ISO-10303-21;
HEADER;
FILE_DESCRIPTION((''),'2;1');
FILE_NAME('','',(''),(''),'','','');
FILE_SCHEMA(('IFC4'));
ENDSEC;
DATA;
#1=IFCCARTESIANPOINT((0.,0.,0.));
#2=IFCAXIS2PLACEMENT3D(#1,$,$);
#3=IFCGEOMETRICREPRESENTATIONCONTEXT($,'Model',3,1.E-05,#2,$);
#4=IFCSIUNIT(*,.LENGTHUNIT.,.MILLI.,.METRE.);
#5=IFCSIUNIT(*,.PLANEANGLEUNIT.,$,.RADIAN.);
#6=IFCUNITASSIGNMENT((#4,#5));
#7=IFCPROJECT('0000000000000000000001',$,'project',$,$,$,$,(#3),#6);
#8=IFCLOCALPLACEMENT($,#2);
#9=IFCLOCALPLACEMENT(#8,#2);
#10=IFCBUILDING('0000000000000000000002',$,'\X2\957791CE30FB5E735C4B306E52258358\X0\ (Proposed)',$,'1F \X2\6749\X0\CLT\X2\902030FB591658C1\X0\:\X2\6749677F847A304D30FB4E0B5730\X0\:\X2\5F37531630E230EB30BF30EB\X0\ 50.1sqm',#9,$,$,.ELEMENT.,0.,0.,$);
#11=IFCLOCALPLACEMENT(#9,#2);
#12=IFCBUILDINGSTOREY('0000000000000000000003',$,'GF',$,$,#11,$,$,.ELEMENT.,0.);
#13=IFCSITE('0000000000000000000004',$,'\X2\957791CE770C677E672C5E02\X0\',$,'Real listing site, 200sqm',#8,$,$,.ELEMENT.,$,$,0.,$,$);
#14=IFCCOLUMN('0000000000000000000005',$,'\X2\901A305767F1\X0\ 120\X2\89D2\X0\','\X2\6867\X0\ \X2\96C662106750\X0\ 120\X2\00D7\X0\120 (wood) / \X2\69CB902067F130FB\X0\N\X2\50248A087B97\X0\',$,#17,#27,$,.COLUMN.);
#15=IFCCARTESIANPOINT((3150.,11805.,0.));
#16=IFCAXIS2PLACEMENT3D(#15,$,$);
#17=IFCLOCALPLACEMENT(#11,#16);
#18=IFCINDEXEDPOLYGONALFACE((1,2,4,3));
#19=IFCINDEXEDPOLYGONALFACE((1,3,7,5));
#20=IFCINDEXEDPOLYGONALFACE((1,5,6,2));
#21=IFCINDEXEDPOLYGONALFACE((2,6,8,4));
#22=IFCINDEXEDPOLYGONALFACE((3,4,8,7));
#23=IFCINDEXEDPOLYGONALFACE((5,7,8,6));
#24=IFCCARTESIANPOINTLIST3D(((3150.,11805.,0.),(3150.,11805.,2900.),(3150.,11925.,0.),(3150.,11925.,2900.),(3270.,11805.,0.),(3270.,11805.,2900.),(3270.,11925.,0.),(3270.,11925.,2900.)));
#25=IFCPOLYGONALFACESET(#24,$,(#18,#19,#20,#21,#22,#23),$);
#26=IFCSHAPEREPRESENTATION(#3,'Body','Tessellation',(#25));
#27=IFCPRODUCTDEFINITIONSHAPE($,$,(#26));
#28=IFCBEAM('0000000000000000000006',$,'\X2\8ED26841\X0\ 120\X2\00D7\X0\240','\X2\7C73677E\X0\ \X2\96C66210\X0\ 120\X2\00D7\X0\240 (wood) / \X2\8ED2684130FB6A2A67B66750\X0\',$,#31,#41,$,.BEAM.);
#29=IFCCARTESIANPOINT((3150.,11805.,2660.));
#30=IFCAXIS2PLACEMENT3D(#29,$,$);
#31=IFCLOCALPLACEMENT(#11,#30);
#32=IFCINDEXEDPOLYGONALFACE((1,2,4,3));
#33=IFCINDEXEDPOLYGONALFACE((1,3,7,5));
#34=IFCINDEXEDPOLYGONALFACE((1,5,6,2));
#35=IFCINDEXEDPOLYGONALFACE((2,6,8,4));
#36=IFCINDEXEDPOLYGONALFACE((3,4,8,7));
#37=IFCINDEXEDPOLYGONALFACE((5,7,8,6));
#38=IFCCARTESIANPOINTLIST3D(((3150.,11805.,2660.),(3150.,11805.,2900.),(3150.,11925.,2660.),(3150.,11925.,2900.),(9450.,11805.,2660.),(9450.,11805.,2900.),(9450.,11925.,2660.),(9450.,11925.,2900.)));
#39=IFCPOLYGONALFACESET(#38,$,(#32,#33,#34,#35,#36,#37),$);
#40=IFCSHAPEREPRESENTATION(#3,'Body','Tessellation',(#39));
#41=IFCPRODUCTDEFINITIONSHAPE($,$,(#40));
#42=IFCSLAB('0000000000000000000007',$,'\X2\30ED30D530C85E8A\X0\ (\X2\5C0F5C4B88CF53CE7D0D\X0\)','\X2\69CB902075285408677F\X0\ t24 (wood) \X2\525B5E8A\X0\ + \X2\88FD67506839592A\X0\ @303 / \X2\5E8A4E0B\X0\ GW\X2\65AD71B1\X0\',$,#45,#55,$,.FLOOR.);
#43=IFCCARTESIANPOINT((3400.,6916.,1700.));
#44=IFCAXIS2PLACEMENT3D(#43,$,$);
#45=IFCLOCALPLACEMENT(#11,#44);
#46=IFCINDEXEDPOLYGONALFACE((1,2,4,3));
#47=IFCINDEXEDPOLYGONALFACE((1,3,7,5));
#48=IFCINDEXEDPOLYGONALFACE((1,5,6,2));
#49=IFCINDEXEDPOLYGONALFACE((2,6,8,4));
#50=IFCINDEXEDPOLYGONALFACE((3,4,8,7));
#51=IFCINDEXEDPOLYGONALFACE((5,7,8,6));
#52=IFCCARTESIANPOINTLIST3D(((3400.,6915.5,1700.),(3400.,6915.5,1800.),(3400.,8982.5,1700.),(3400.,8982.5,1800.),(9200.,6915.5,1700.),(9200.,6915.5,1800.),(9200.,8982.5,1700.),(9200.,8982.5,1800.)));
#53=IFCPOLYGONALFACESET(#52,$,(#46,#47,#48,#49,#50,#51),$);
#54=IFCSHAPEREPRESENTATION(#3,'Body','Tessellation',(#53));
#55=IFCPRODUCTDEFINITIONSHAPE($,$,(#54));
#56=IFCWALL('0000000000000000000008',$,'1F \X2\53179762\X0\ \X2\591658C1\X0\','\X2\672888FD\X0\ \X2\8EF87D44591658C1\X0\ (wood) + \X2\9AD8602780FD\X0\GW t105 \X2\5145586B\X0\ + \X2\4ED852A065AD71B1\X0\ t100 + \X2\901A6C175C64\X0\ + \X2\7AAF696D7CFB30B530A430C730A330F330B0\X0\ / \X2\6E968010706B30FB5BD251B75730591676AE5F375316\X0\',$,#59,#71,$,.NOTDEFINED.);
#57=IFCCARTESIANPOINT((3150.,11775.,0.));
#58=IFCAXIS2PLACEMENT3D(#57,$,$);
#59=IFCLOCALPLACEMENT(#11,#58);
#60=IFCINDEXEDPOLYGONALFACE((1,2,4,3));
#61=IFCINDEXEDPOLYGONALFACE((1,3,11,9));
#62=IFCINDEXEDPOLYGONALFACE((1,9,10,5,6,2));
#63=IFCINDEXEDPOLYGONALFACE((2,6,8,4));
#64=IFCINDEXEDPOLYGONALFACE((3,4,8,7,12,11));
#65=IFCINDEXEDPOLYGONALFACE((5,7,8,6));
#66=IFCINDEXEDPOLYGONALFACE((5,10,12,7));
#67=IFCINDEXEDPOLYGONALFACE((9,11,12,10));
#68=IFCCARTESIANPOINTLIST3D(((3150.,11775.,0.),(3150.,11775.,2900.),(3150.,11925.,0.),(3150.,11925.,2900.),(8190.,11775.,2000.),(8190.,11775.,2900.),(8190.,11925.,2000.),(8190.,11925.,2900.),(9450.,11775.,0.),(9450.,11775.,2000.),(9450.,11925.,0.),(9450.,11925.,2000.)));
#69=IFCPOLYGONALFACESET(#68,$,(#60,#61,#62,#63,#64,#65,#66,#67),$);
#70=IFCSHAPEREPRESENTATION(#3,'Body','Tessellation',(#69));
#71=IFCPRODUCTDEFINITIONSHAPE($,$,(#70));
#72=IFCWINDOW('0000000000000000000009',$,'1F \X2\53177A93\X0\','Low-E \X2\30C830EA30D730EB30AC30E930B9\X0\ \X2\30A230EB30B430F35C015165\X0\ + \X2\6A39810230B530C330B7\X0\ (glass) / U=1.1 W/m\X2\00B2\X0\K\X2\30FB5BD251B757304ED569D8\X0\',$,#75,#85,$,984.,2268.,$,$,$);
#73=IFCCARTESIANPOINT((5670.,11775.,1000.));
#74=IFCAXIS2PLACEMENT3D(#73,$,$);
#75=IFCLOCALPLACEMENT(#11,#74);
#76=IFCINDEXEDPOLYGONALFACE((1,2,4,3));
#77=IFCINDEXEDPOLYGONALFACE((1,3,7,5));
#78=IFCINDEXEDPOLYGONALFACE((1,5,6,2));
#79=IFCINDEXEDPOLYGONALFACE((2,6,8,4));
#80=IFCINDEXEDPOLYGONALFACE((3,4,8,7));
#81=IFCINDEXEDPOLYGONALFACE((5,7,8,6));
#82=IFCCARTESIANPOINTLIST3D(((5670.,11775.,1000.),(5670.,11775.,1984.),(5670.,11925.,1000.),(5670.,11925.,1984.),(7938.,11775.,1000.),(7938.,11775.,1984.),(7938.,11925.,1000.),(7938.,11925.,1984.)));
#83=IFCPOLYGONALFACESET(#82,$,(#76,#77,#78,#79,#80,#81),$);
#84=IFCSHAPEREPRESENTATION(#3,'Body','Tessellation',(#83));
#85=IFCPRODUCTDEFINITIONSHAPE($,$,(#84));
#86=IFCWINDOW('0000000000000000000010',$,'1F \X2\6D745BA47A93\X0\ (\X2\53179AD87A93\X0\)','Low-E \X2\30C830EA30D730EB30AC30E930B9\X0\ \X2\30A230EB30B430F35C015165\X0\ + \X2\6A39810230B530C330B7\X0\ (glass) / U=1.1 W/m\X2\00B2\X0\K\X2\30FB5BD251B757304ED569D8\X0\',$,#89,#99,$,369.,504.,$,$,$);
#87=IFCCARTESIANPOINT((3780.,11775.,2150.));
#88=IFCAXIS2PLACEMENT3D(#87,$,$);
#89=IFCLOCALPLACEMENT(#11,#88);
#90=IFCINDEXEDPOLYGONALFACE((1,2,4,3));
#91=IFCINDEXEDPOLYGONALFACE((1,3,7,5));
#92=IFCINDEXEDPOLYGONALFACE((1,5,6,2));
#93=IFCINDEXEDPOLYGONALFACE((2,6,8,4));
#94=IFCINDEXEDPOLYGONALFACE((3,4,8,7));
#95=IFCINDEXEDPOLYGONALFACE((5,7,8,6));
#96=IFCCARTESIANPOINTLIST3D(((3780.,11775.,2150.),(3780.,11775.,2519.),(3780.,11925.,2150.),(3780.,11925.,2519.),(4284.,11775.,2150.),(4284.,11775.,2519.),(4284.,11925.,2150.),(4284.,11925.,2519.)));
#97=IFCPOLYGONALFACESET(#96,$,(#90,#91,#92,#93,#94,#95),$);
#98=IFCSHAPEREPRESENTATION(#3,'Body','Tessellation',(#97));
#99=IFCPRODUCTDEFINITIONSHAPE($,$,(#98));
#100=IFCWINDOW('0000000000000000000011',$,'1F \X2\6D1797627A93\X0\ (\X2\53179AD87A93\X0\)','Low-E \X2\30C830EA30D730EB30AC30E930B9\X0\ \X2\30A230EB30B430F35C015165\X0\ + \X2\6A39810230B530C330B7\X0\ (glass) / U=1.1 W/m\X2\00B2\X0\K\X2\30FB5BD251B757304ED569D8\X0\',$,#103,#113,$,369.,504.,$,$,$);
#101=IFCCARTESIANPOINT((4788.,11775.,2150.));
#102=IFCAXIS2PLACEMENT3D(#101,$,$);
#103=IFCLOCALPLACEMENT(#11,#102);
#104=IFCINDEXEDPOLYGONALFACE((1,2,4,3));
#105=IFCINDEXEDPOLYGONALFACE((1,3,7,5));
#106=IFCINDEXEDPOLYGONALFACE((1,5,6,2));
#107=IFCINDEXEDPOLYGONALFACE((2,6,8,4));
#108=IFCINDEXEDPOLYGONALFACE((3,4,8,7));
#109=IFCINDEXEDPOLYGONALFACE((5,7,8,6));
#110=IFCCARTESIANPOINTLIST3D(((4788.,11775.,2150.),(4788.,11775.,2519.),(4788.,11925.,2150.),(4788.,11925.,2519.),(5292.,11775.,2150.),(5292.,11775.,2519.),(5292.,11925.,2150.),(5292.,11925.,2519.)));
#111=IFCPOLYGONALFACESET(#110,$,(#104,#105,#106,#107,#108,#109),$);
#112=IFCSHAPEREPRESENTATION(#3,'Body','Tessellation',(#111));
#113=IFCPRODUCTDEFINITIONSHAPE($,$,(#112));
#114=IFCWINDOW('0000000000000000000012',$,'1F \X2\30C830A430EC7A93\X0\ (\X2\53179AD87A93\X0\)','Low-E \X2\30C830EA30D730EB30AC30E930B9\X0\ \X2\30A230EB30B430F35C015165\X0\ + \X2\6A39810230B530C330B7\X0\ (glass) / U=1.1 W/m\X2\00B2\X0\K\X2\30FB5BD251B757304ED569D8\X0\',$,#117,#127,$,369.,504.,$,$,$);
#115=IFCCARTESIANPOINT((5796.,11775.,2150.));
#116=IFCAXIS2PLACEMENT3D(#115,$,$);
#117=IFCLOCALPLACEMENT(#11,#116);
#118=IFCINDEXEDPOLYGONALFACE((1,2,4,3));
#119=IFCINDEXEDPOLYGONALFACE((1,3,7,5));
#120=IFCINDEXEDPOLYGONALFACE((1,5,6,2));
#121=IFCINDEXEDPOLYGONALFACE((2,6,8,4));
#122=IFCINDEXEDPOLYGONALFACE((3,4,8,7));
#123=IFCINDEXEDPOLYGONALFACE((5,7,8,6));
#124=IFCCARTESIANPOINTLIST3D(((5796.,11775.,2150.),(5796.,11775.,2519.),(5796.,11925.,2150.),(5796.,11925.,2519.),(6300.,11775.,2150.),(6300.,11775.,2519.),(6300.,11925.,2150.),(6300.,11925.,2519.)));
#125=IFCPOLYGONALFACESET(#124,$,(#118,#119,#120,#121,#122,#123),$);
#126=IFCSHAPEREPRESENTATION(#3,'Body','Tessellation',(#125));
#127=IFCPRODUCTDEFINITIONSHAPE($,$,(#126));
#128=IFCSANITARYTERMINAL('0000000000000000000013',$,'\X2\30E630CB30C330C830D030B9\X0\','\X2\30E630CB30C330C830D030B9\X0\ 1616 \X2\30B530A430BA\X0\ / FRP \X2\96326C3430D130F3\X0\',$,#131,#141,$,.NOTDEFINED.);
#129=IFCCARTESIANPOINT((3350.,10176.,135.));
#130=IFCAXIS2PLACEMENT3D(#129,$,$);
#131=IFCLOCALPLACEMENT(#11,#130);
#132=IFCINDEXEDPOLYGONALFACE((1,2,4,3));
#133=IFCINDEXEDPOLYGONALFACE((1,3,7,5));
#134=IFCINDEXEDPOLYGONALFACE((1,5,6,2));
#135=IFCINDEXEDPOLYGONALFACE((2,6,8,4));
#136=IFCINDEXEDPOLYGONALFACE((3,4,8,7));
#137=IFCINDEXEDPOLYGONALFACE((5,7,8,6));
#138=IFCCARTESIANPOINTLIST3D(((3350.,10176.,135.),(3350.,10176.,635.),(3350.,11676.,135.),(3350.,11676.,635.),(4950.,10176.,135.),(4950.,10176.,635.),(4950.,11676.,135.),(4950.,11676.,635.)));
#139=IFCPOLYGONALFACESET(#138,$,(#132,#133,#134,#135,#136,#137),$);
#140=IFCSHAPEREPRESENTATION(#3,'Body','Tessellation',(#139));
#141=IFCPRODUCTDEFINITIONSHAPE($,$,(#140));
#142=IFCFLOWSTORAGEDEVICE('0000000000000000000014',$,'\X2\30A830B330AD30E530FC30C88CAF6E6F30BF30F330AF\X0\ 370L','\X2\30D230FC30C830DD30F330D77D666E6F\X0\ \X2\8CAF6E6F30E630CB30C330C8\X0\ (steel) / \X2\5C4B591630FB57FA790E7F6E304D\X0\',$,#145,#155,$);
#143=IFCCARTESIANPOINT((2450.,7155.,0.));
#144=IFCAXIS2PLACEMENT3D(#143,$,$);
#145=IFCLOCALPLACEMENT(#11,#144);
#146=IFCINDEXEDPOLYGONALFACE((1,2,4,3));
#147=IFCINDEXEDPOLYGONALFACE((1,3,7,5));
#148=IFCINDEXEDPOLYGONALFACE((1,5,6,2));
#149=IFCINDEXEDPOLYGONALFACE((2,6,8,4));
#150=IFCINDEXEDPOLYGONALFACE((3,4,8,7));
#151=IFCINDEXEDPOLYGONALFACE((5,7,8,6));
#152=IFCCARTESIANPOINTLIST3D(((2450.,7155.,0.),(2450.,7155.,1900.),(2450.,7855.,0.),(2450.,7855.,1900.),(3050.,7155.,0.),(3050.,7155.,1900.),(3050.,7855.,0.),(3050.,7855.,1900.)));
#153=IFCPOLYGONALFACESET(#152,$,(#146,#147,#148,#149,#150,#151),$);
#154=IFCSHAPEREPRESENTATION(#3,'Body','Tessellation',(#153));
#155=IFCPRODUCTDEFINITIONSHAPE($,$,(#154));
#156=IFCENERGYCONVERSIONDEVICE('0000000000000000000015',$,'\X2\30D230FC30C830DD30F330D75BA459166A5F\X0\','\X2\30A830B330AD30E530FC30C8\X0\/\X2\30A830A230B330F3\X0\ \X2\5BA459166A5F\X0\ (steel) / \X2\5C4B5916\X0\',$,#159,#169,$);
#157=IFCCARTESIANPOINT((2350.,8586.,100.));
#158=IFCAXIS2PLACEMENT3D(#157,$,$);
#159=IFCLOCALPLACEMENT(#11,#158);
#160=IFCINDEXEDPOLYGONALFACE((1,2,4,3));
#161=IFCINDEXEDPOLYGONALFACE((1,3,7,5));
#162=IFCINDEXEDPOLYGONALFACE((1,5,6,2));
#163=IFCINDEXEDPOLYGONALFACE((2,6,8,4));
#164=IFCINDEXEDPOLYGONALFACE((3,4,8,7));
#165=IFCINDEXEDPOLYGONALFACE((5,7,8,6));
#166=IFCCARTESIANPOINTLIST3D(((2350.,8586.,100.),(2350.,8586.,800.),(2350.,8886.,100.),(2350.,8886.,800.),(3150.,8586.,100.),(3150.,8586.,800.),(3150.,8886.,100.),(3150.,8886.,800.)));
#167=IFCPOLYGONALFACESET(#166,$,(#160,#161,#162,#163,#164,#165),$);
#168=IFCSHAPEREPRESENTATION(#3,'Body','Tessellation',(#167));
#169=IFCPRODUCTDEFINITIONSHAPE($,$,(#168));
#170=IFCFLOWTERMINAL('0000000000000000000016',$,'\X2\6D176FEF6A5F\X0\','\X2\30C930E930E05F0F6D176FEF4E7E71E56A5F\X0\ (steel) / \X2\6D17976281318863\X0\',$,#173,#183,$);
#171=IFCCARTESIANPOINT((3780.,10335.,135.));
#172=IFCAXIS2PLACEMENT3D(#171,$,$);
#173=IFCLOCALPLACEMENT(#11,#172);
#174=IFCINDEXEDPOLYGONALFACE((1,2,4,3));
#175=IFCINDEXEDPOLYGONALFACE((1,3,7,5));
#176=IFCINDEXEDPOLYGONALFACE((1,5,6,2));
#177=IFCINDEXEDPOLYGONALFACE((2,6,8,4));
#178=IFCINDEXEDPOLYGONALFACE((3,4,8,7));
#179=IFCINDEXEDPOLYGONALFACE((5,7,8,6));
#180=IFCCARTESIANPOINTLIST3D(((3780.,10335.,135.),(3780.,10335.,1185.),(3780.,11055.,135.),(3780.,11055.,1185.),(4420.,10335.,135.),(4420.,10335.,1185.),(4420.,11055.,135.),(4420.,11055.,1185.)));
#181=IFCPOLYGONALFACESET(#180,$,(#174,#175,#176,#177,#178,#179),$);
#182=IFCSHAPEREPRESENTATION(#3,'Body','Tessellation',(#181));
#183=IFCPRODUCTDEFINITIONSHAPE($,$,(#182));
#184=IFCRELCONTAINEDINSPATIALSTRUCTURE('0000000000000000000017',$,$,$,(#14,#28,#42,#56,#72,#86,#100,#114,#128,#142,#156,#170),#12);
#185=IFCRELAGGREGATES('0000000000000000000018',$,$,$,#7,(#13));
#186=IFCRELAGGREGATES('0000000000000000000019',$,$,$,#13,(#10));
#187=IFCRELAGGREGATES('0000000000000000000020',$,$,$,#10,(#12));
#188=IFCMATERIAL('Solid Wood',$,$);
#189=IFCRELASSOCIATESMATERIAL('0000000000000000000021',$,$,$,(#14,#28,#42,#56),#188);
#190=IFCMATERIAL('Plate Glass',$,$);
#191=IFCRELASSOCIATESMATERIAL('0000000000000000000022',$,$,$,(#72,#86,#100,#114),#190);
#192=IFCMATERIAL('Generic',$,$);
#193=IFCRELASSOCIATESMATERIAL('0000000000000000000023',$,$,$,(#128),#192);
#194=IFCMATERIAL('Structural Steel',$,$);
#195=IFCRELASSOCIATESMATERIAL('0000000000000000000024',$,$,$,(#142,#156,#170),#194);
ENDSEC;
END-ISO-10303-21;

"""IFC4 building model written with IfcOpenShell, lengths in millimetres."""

from ifc_helpers import new_model, si_unit, frame, frame_2d, origin, place, context, project, spatial, rectangle, extrude, material, element, fill, save


model = new_model("IFC4")

# Units and contexts
model_context = context("Model", 3, precision=1e-05, world=origin())
ifc_project = project(units=[si_unit("LENGTHUNIT", "METRE", prefix="MILLI"), si_unit("PLANEANGLEUNIT", "RADIAN")], contexts=[model_context])

# Site, building, storey
site_placement = place(None, origin())
site = spatial("IfcSite", under=ifc_project, at=site_placement, Name="長野県松本市", ObjectType="Real listing site, 200sqm", CompositionType="ELEMENT", RefElevation=0.0)
building_placement = place(site_placement, origin())
building = spatial("IfcBuilding", under=site, at=building_placement, Name="長野・平屋の別荘 (Proposed)", ObjectType="1F 杉CLT造・外壁:杉板葺き・下地:強化モルタル 50.1sqm", CompositionType="ELEMENT", ElevationOfRefHeight=0.0, ElevationOfTerrain=0.0)
storey_placement = place(building_placement, origin())
storey = spatial("IfcBuildingStorey", under=building, at=storey_placement, Name="GF", CompositionType="ELEMENT", Elevation=0.0)

# Column
ifc_material_1 = material(Name="Solid Wood")
column_1_placement = place(storey_placement, frame((3150.0, 11805.0, 0.0)))
element("IfcColumn", 1, at=column_1_placement, inside=storey, material=ifc_material_1, Name="通し柱 120角", Description="桧 集成材 120×120 (wood) / 構造柱・N値計算", PredefinedType="COLUMN", context=model_context, shape_type="SweptSolid", body=[
    extrude(rectangle(XDim=120.0, YDim=120.0, at=frame_2d((60.0, 60.0))), frame((3150.0, 11805.0, 0.0)), (0.0, 0.0, 1.0), 2900.0),
])

# Beam
beam_1_placement = place(storey_placement, frame((3150.0, 11805.0, 2660.0)))
element("IfcBeam", 2, at=beam_1_placement, inside=storey, material=ifc_material_1, Name="軒桁 120×240", Description="米松 集成 120×240 (wood) / 軒桁・横架材", PredefinedType="BEAM", context=model_context, shape_type="SweptSolid", body=[
    extrude(rectangle(XDim=6300.0, YDim=120.0, at=frame_2d((3150.0, 60.0))), frame((3150.0, 11805.0, 2660.0)), (0.0, 0.0, 1.0), 240.0),
])

# Slab
slab_placement = place(storey_placement, frame((3400.0, 6916.0, 1700.0)))
element("IfcSlab", 3, at=slab_placement, inside=storey, material=ifc_material_1, Name="ロフト床 (小屋裏収納)", Description="構造用合板 t24 (wood) 剛床 + 製材根太 @303 / 床下 GW断熱", PredefinedType="FLOOR", context=model_context, shape_type="SweptSolid", body=[
    extrude(rectangle(XDim=5800.0, YDim=2067.0, at=frame_2d((2900.0, 1033.0))), frame((3400.0, 6916.0, 1700.0)), (0.0, 0.0, 1.0), 100.0),
])

# Wall, openings, windows
wall_1_placement = place(storey_placement, frame((3150.0, 11775.0, 0.0)))
wall_1 = element("IfcWall", 4, at=wall_1_placement, inside=storey, material=ifc_material_1, Name="1F 北面 外壁", Description="木製 軸組外壁 (wood) + 高性能GW t105 充填 + 付加断熱 t100 + 通気層 + 窯業系サイディング / 準耐火・寒冷地外皮強化", PredefinedType="NOTDEFINED", context=model_context, shape_type="SweptSolid", body=[
    extrude(rectangle(XDim=6300.0, YDim=150.0, at=frame_2d((3150.0, 75.0))), frame((3150.0, 11775.0, 0.0)), (0.0, 0.0, 1.0), 2900.0),
])
opening_1_placement = place(storey_placement, frame((5670.0, 11775.0, 1000.0)))
opening_1 = element("IfcOpeningElement", 5, at=opening_1_placement, cuts=wall_1, PredefinedType="NOTDEFINED", context=model_context, shape_type="SweptSolid", body=[
    extrude(rectangle(XDim=2268.0, YDim=150.0, at=frame_2d((1134.0, 75.0))), frame((5670.0, 11775.0, 1000.0)), (0.0, 0.0, 1.0), 984.0),
])
opening_2_placement = place(storey_placement, frame((3780.0, 11775.0, 2150.0)))
opening_2 = element("IfcOpeningElement", 6, at=opening_2_placement, cuts=wall_1, PredefinedType="NOTDEFINED", context=model_context, shape_type="SweptSolid", body=[
    extrude(rectangle(XDim=504.0, YDim=150.0, at=frame_2d((252.0, 75.0))), frame((3780.0, 11775.0, 2150.0)), (0.0, 0.0, 1.0), 369.0),
])
opening_3_placement = place(storey_placement, frame((4788.0, 11775.0, 2150.0)))
opening_3 = element("IfcOpeningElement", 7, at=opening_3_placement, cuts=wall_1, PredefinedType="NOTDEFINED", context=model_context, shape_type="SweptSolid", body=[
    extrude(rectangle(XDim=504.0, YDim=150.0, at=frame_2d((252.0, 75.0))), frame((4788.0, 11775.0, 2150.0)), (0.0, 0.0, 1.0), 369.0),
])
opening_4_placement = place(storey_placement, frame((5796.0, 11775.0, 2150.0)))
opening_4 = element("IfcOpeningElement", 8, at=opening_4_placement, cuts=wall_1, PredefinedType="NOTDEFINED", context=model_context, shape_type="SweptSolid", body=[
    extrude(rectangle(XDim=504.0, YDim=150.0, at=frame_2d((252.0, 75.0))), frame((5796.0, 11775.0, 2150.0)), (0.0, 0.0, 1.0), 369.0),
])
ifc_material_2 = material(Name="Plate Glass")
window_1_placement = place(storey_placement, frame((5670.0, 11775.0, 1000.0)))
window_1 = element("IfcWindow", 9, at=window_1_placement, inside=storey, material=ifc_material_2, Name="1F 北窓", Description="Low-E トリプルガラス アルゴン封入 + 樹脂サッシ (glass) / U=1.1 W/m²K・寒冷地仕様", OverallHeight=984.0, OverallWidth=2268.0, context=model_context, shape_type="SweptSolid", body=[
    extrude(rectangle(XDim=2268.0, YDim=150.0, at=frame_2d((1134.0, 75.0))), frame((5670.0, 11775.0, 1000.0)), (0.0, 0.0, 1.0), 984.0),
])
fill(opening_1, window_1)
window_2_placement = place(storey_placement, frame((3780.0, 11775.0, 2150.0)))
window_2 = element("IfcWindow", 10, at=window_2_placement, inside=storey, material=ifc_material_2, Name="1F 浴室窓 (北高窓)", Description="Low-E トリプルガラス アルゴン封入 + 樹脂サッシ (glass) / U=1.1 W/m²K・寒冷地仕様", OverallHeight=369.0, OverallWidth=504.0, context=model_context, shape_type="SweptSolid", body=[
    extrude(rectangle(XDim=504.0, YDim=150.0, at=frame_2d((252.0, 75.0))), frame((3780.0, 11775.0, 2150.0)), (0.0, 0.0, 1.0), 369.0),
])
fill(opening_2, window_2)
window_3_placement = place(storey_placement, frame((4788.0, 11775.0, 2150.0)))
window_3 = element("IfcWindow", 11, at=window_3_placement, inside=storey, material=ifc_material_2, Name="1F 洗面窓 (北高窓)", Description="Low-E トリプルガラス アルゴン封入 + 樹脂サッシ (glass) / U=1.1 W/m²K・寒冷地仕様", OverallHeight=369.0, OverallWidth=504.0, context=model_context, shape_type="SweptSolid", body=[
    extrude(rectangle(XDim=504.0, YDim=150.0, at=frame_2d((252.0, 75.0))), frame((4788.0, 11775.0, 2150.0)), (0.0, 0.0, 1.0), 369.0),
])
fill(opening_3, window_3)
window_4_placement = place(storey_placement, frame((5796.0, 11775.0, 2150.0)))
window_4 = element("IfcWindow", 12, at=window_4_placement, inside=storey, material=ifc_material_2, Name="1F トイレ窓 (北高窓)", Description="Low-E トリプルガラス アルゴン封入 + 樹脂サッシ (glass) / U=1.1 W/m²K・寒冷地仕様", OverallHeight=369.0, OverallWidth=504.0, context=model_context, shape_type="SweptSolid", body=[
    extrude(rectangle(XDim=504.0, YDim=150.0, at=frame_2d((252.0, 75.0))), frame((5796.0, 11775.0, 2150.0)), (0.0, 0.0, 1.0), 369.0),
])
fill(opening_4, window_4)

# Sanitary terminal
ifc_material_3 = material(Name="Generic")
sanitary_terminal_placement = place(storey_placement, frame((3350.0, 10176.0, 135.0)))
element("IfcSanitaryTerminal", 13, at=sanitary_terminal_placement, inside=storey, material=ifc_material_3, Name="ユニットバス", Description="ユニットバス 1616 サイズ / FRP 防水パン", PredefinedType="NOTDEFINED", context=model_context, shape_type="SweptSolid", body=[
    extrude(rectangle(XDim=1600.0, YDim=1500.0, at=frame_2d((800.0, 750.0))), frame((3350.0, 10176.0, 135.0)), (0.0, 0.0, 1.0), 500.0),
])

# Flow storage device
ifc_material_4 = material(Name="Structural Steel")
flow_storage_device_placement = place(storey_placement, frame((2450.0, 7155.0, 0.0)))
element("IfcFlowStorageDevice", 14, at=flow_storage_device_placement, inside=storey, material=ifc_material_4, Name="エコキュート貯湯タンク 370L", Description="ヒートポンプ給湯 貯湯ユニット (steel) / 屋外・基礎置き", context=model_context, shape_type="SweptSolid", body=[
    extrude(rectangle(XDim=600.0, YDim=700.0, at=frame_2d((300.0, 350.0))), frame((2450.0, 7155.0, 0.0)), (0.0, 0.0, 1.0), 1900.0),
])

# Energy conversion device
energy_conversion_device_placement = place(storey_placement, frame((2350.0, 8586.0, 100.0)))
element("IfcEnergyConversionDevice", 15, at=energy_conversion_device_placement, inside=storey, material=ifc_material_4, Name="ヒートポンプ室外機", Description="エコキュート/エアコン 室外機 (steel) / 屋外", context=model_context, shape_type="SweptSolid", body=[
    extrude(rectangle(XDim=800.0, YDim=300.0, at=frame_2d((400.0, 150.0))), frame((2350.0, 8586.0, 100.0)), (0.0, 0.0, 1.0), 700.0),
])

# Flow terminal
flow_terminal_placement = place(storey_placement, frame((3780.0, 10335.0, 135.0)))
element("IfcFlowTerminal", 16, at=flow_terminal_placement, inside=storey, material=ifc_material_4, Name="洗濯機", Description="ドラム式洗濯乾燥機 (steel) / 洗面脱衣", context=model_context, shape_type="SweptSolid", body=[
    extrude(rectangle(XDim=640.0, YDim=720.0, at=frame_2d((320.0, 360.0))), frame((3780.0, 10335.0, 135.0)), (0.0, 0.0, 1.0), 1050.0),
])

save(model, "model.ifc")
